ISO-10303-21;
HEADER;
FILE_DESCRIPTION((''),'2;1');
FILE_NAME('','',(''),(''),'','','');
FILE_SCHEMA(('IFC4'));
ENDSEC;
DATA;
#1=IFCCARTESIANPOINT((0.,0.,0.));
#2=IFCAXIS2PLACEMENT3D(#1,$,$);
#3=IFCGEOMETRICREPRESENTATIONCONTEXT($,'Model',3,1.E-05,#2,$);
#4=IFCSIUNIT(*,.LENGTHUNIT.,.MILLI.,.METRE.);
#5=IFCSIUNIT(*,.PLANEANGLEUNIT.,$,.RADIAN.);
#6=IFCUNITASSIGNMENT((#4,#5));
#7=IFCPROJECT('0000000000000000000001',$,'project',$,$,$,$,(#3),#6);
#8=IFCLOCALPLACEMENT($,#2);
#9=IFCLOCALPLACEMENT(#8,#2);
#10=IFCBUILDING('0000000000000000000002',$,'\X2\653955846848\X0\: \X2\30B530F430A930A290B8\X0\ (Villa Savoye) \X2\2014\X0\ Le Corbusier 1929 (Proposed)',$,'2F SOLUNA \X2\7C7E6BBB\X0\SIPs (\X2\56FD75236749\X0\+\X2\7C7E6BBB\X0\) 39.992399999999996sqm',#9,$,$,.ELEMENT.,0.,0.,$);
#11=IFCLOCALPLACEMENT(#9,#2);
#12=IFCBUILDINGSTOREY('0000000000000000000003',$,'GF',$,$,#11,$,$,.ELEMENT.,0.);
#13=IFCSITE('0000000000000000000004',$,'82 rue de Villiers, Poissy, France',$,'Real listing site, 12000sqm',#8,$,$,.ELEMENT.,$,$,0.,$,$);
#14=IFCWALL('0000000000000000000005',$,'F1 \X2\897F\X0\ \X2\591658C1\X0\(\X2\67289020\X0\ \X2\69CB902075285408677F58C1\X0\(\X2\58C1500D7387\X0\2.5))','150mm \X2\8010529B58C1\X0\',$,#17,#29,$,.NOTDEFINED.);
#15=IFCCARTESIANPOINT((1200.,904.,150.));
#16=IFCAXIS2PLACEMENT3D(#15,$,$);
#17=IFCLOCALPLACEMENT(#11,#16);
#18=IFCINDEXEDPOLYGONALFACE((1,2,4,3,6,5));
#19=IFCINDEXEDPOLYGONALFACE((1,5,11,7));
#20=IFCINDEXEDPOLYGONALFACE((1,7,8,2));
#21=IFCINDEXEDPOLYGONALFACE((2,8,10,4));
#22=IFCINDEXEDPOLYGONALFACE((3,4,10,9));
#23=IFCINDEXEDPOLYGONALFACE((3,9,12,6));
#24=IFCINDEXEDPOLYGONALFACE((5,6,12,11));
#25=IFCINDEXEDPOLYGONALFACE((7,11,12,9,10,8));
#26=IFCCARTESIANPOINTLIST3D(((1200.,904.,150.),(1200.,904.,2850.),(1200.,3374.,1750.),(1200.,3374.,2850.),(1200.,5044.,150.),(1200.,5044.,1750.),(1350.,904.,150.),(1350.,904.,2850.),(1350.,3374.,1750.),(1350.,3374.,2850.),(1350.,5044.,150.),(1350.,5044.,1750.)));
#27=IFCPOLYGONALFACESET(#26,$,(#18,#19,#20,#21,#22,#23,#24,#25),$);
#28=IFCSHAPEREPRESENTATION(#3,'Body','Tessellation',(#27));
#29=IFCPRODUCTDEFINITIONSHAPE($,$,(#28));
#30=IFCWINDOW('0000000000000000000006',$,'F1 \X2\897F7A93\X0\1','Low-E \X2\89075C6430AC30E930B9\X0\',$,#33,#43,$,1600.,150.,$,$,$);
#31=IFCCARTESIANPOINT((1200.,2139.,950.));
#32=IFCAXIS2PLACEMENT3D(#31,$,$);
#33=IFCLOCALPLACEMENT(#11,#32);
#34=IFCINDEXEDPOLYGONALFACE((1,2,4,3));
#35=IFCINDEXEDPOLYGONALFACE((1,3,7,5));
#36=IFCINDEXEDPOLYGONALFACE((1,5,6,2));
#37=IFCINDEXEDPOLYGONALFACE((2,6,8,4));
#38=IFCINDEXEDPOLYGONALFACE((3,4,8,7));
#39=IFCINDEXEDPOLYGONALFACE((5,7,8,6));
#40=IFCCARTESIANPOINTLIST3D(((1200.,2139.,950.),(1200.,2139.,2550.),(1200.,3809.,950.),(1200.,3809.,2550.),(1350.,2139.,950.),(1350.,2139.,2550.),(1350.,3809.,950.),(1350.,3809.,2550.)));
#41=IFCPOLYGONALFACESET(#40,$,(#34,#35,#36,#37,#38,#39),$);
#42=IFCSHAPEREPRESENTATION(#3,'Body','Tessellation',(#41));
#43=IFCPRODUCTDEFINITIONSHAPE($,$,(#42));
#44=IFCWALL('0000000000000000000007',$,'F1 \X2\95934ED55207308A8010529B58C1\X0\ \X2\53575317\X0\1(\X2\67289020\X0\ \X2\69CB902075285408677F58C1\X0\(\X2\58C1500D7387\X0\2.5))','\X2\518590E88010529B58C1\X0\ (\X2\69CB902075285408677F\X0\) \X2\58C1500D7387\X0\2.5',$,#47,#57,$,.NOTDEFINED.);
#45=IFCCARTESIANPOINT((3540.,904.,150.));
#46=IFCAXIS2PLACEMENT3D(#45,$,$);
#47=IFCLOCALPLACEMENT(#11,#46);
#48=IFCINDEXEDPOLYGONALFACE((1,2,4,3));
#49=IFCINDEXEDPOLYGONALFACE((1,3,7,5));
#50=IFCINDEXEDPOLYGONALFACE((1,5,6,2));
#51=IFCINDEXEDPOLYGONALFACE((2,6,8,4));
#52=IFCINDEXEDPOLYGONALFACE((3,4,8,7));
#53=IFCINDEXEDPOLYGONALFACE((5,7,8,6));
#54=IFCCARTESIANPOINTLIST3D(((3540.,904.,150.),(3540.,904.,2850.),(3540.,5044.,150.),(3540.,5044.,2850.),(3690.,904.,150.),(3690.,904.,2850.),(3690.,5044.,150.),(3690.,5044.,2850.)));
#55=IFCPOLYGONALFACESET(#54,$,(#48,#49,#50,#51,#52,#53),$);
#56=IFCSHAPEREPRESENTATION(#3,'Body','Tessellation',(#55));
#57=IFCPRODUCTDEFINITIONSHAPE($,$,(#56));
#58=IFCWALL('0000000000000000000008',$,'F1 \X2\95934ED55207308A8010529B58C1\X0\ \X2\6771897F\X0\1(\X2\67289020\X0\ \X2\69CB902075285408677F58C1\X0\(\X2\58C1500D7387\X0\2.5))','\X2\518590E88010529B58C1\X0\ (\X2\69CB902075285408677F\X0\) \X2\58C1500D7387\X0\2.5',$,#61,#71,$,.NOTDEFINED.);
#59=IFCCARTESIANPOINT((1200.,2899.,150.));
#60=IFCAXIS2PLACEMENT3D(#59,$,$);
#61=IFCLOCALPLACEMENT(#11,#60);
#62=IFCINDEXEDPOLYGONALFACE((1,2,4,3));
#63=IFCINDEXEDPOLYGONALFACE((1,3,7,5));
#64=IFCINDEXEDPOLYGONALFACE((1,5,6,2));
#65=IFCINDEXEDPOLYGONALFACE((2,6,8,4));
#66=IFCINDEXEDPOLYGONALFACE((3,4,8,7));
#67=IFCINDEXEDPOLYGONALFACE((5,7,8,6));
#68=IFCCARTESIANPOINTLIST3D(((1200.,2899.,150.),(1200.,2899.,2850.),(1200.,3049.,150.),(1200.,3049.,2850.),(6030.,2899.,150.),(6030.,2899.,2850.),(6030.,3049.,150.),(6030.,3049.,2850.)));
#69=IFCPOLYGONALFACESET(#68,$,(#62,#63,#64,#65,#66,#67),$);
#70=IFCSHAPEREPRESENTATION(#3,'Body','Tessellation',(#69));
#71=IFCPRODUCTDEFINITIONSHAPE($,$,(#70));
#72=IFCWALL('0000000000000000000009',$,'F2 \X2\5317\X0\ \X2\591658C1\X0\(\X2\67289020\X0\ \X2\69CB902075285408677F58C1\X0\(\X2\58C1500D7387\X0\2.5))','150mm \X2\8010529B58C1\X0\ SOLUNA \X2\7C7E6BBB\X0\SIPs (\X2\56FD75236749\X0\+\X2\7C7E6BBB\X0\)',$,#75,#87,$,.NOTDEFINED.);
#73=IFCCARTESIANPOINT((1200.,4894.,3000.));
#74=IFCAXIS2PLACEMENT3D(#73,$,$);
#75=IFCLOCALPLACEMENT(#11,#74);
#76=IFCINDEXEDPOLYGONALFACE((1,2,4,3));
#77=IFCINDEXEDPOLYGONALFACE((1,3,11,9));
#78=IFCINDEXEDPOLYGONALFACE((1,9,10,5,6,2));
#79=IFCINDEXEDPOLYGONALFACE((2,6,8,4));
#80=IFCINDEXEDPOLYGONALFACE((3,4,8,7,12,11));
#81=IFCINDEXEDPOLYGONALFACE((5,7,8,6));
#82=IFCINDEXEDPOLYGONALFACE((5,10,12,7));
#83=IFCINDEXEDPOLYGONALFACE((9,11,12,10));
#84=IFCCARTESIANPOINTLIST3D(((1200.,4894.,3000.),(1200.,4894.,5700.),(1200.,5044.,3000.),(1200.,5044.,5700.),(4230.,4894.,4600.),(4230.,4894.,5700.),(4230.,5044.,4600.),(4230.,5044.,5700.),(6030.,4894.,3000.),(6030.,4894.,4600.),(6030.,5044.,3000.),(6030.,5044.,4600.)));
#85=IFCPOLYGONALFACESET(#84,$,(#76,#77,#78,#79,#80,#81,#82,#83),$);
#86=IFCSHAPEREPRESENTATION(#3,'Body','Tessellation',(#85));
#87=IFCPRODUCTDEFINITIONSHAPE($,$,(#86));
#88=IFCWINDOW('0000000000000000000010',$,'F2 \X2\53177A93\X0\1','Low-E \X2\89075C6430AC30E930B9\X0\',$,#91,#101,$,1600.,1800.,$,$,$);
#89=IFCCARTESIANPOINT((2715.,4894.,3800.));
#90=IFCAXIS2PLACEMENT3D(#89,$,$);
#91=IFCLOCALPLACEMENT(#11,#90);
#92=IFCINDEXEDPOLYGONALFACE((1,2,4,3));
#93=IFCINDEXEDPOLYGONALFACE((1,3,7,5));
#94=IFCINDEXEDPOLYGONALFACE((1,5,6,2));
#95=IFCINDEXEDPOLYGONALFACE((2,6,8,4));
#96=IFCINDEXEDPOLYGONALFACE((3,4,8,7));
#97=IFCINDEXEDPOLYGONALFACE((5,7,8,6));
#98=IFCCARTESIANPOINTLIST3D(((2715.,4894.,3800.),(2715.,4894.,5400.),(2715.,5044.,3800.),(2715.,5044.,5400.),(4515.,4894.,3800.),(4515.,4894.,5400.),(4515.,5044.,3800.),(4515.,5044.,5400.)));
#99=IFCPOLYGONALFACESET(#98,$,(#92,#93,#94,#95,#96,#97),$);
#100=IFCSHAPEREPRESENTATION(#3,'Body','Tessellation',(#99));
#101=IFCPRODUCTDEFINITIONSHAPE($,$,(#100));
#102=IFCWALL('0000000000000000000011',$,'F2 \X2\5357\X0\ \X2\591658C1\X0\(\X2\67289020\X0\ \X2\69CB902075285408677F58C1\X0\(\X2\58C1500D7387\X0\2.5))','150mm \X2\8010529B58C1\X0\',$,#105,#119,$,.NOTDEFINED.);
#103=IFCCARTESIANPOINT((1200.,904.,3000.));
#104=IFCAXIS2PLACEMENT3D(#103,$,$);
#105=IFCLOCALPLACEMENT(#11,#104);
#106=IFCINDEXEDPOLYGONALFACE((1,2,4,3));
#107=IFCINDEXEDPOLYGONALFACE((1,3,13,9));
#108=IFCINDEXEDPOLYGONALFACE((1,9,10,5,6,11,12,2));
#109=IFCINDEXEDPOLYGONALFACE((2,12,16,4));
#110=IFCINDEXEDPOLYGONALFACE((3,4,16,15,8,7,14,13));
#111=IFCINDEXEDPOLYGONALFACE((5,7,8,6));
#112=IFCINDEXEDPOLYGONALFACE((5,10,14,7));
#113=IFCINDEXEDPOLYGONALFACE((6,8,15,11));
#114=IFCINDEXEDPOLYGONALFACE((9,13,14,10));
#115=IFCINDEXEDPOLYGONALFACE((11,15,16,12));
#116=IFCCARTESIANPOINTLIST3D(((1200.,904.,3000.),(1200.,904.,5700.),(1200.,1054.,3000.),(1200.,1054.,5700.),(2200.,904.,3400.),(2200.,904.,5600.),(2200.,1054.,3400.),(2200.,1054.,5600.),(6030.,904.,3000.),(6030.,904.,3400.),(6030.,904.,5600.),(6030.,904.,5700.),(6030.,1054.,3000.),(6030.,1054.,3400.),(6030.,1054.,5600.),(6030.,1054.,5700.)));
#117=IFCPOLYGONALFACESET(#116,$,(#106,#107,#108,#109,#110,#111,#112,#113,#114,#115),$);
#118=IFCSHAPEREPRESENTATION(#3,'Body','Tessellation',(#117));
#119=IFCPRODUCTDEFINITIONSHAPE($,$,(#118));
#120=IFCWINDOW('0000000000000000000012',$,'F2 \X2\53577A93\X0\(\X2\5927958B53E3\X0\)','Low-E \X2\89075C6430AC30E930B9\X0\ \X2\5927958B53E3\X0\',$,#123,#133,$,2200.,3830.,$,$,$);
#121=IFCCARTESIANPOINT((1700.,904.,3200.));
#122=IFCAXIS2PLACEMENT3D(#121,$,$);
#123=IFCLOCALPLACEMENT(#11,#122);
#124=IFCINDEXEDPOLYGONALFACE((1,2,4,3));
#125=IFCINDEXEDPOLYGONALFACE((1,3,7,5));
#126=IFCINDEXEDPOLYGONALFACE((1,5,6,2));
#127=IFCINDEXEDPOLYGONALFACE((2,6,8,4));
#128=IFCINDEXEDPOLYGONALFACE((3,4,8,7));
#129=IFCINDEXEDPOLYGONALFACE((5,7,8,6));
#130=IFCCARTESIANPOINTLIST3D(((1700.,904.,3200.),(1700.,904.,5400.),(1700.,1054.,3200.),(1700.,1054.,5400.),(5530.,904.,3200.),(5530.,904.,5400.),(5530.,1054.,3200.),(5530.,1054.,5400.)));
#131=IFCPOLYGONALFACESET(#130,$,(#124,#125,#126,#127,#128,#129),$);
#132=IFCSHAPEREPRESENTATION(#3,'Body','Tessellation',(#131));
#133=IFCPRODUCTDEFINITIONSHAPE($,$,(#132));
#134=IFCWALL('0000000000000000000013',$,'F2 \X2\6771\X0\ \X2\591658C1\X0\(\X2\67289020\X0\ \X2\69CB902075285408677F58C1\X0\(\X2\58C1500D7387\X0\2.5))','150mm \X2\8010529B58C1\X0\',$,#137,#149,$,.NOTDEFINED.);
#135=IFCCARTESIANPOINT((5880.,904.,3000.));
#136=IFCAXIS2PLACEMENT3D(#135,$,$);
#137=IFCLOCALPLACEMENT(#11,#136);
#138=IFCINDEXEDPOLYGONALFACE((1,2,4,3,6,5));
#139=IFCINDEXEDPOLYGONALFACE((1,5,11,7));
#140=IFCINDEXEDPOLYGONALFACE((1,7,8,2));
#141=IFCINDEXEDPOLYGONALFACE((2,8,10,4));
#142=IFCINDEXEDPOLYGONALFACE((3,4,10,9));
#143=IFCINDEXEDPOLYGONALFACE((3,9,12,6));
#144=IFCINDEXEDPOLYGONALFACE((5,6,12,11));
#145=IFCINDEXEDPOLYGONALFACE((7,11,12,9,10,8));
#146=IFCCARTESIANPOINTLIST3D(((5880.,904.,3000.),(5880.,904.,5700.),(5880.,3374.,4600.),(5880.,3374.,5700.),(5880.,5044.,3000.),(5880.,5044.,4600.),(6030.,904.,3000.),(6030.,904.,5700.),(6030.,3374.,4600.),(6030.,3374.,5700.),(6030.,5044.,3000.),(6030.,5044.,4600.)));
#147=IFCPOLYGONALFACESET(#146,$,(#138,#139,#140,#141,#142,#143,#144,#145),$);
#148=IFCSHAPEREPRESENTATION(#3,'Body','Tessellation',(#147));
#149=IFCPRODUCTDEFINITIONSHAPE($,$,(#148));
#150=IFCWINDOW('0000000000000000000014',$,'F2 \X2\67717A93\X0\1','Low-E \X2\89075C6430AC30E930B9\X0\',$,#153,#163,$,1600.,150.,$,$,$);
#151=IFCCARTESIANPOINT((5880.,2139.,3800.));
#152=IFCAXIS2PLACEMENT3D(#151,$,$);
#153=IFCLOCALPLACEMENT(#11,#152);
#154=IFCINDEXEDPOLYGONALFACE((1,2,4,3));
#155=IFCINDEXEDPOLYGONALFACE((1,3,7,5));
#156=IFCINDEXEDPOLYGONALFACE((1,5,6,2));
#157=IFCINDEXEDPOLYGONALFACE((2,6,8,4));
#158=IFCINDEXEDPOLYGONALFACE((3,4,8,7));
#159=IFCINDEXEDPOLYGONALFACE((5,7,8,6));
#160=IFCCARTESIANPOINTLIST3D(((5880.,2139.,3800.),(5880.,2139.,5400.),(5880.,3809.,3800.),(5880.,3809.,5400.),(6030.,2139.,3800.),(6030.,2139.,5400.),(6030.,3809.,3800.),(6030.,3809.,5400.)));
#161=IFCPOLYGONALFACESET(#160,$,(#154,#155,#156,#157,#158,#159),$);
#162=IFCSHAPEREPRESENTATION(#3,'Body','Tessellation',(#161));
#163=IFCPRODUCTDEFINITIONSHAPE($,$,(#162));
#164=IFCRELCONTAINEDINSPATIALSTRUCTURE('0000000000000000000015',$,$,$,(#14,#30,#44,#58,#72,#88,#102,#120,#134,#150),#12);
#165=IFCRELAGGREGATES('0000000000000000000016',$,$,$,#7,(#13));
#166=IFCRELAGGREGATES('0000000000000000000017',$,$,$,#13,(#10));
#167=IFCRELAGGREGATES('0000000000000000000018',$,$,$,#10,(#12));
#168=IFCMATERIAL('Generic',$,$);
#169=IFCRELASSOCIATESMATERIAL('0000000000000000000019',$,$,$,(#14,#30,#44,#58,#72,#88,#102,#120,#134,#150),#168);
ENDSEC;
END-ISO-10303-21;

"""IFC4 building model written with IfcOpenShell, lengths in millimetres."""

from ifc_helpers import new_model, si_unit, frame, frame_2d, origin, place, context, project, spatial, rectangle, extrude, material, element, fill, save


model = new_model("IFC4")

# Units and contexts
model_context = context("Model", 3, precision=1e-05, world=origin())
ifc_project = project(units=[si_unit("LENGTHUNIT", "METRE", prefix="MILLI"), si_unit("PLANEANGLEUNIT", "RADIAN")], contexts=[model_context])

# Site, building, storey
site_placement = place(None, origin())
site = spatial("IfcSite", under=ifc_project, at=site_placement, Name="82 rue de Villiers, Poissy, France", ObjectType="Real listing site, 12000sqm", CompositionType="ELEMENT", RefElevation=0.0)
building_placement = place(site_placement, origin())
building = spatial("IfcBuilding", under=site, at=building_placement, Name="改善案: サヴォア邸 (Villa Savoye) — Le Corbusier 1929 (Proposed)", ObjectType="2F SOLUNA 籾殻SIPs (国産杉+籾殻) 39.992399999999996sqm", CompositionType="ELEMENT", ElevationOfRefHeight=0.0, ElevationOfTerrain=0.0)
storey_placement = place(building_placement, origin())
storey = spatial("IfcBuildingStorey", under=building, at=storey_placement, Name="GF", CompositionType="ELEMENT", Elevation=0.0)

# Shared definitions
ifc_material_1 = material(Name="Generic")

# Wall, opening, window
wall_1_placement = place(storey_placement, frame((1200.0, 904.0, 150.0)))
wall_1 = element("IfcWall", 1, at=wall_1_placement, inside=storey, material=ifc_material_1, Name="F1 西 外壁(木造 構造用合板壁(壁倍率2.5))", Description="150mm 耐力壁", PredefinedType="NOTDEFINED", context=model_context, shape_type="SweptSolid", body=[
    extrude(rectangle(XDim=150.0, YDim=4140.0, at=frame_2d((75.0, 2070.0))), frame((1200.0, 904.0, 150.0)), (0.0, 0.0, 1.0), 2700.0),
])
opening_1_placement = place(storey_placement, frame((1200.0, 2139.0, 950.0)))
opening_1 = element("IfcOpeningElement", 2, at=opening_1_placement, cuts=wall_1, PredefinedType="NOTDEFINED", context=model_context, shape_type="SweptSolid", body=[
    extrude(rectangle(XDim=150.0, YDim=1670.0, at=frame_2d((75.0, 835.0))), frame((1200.0, 2139.0, 950.0)), (0.0, 0.0, 1.0), 1600.0),
])
window_1_placement = place(storey_placement, frame((1200.0, 2139.0, 950.0)))
window_1 = element("IfcWindow", 3, at=window_1_placement, inside=storey, material=ifc_material_1, Name="F1 西窓1", Description="Low-E 複層ガラス", OverallHeight=1600.0, OverallWidth=150.0, context=model_context, shape_type="SweptSolid", body=[
    extrude(rectangle(XDim=150.0, YDim=1670.0, at=frame_2d((75.0, 835.0))), frame((1200.0, 2139.0, 950.0)), (0.0, 0.0, 1.0), 1600.0),
])
fill(opening_1, window_1)

# Walls
wall_2_placement = place(storey_placement, frame((3540.0, 904.0, 150.0)))
element("IfcWall", 4, at=wall_2_placement, inside=storey, material=ifc_material_1, Name="F1 間仕切り耐力壁 南北1(木造 構造用合板壁(壁倍率2.5))", Description="内部耐力壁 (構造用合板) 壁倍率2.5", PredefinedType="NOTDEFINED", context=model_context, shape_type="SweptSolid", body=[
    extrude(rectangle(XDim=150.0, YDim=4140.0, at=frame_2d((75.0, 2070.0))), frame((3540.0, 904.0, 150.0)), (0.0, 0.0, 1.0), 2700.0),
])
wall_3_placement = place(storey_placement, frame((1200.0, 2899.0, 150.0)))
element("IfcWall", 5, at=wall_3_placement, inside=storey, material=ifc_material_1, Name="F1 間仕切り耐力壁 東西1(木造 構造用合板壁(壁倍率2.5))", Description="内部耐力壁 (構造用合板) 壁倍率2.5", PredefinedType="NOTDEFINED", context=model_context, shape_type="SweptSolid", body=[
    extrude(rectangle(XDim=4830.0, YDim=150.0, at=frame_2d((2415.0, 75.0))), frame((1200.0, 2899.0, 150.0)), (0.0, 0.0, 1.0), 2700.0),
])

# Walls, openings, windows
wall_4_placement = place(storey_placement, frame((1200.0, 4894.0, 3000.0)))
wall_4 = element("IfcWall", 6, at=wall_4_placement, inside=storey, material=ifc_material_1, Name="F2 北 外壁(木造 構造用合板壁(壁倍率2.5))", Description="150mm 耐力壁 SOLUNA 籾殻SIPs (国産杉+籾殻)", PredefinedType="NOTDEFINED", context=model_context, shape_type="SweptSolid", body=[
    extrude(rectangle(XDim=4830.0, YDim=150.0, at=frame_2d((2415.0, 75.0))), frame((1200.0, 4894.0, 3000.0)), (0.0, 0.0, 1.0), 2700.0),
])
opening_2_placement = place(storey_placement, frame((2715.0, 4894.0, 3800.0)))
opening_2 = element("IfcOpeningElement", 7, at=opening_2_placement, cuts=wall_4, PredefinedType="NOTDEFINED", context=model_context, shape_type="SweptSolid", body=[
    extrude(rectangle(XDim=1800.0, YDim=150.0, at=frame_2d((900.0, 75.0))), frame((2715.0, 4894.0, 3800.0)), (0.0, 0.0, 1.0), 1600.0),
])
window_2_placement = place(storey_placement, frame((2715.0, 4894.0, 3800.0)))
window_2 = element("IfcWindow", 8, at=window_2_placement, inside=storey, material=ifc_material_1, Name="F2 北窓1", Description="Low-E 複層ガラス", OverallHeight=1600.0, OverallWidth=1800.0, context=model_context, shape_type="SweptSolid", body=[
    extrude(rectangle(XDim=1800.0, YDim=150.0, at=frame_2d((900.0, 75.0))), frame((2715.0, 4894.0, 3800.0)), (0.0, 0.0, 1.0), 1600.0),
])
fill(opening_2, window_2)
wall_5_placement = place(storey_placement, frame((1200.0, 904.0, 3000.0)))
wall_5 = element("IfcWall", 9, at=wall_5_placement, inside=storey, material=ifc_material_1, Name="F2 南 外壁(木造 構造用合板壁(壁倍率2.5))", Description="150mm 耐力壁", PredefinedType="NOTDEFINED", context=model_context, shape_type="SweptSolid", body=[
    extrude(rectangle(XDim=4830.0, YDim=150.0, at=frame_2d((2415.0, 75.0))), frame((1200.0, 904.0, 3000.0)), (0.0, 0.0, 1.0), 2700.0),
])
opening_3_placement = place(storey_placement, frame((1700.0, 904.0, 3200.0)))
opening_3 = element("IfcOpeningElement", 10, at=opening_3_placement, cuts=wall_5, PredefinedType="NOTDEFINED", context=model_context, shape_type="SweptSolid", body=[
    extrude(rectangle(XDim=3830.0, YDim=150.0, at=frame_2d((1915.0, 75.0))), frame((1700.0, 904.0, 3200.0)), (0.0, 0.0, 1.0), 2200.0),
])
window_3_placement = place(storey_placement, frame((1700.0, 904.0, 3200.0)))
window_3 = element("IfcWindow", 11, at=window_3_placement, inside=storey, material=ifc_material_1, Name="F2 南窓(大開口)", Description="Low-E 複層ガラス 大開口", OverallHeight=2200.0, OverallWidth=3830.0, context=model_context, shape_type="SweptSolid", body=[
    extrude(rectangle(XDim=3830.0, YDim=150.0, at=frame_2d((1915.0, 75.0))), frame((1700.0, 904.0, 3200.0)), (0.0, 0.0, 1.0), 2200.0),
])
fill(opening_3, window_3)
wall_6_placement = place(storey_placement, frame((5880.0, 904.0, 3000.0)))
wall_6 = element("IfcWall", 12, at=wall_6_placement, inside=storey, material=ifc_material_1, Name="F2 東 外壁(木造 構造用合板壁(壁倍率2.5))", Description="150mm 耐力壁", PredefinedType="NOTDEFINED", context=model_context, shape_type="SweptSolid", body=[
    extrude(rectangle(XDim=150.0, YDim=4140.0, at=frame_2d((75.0, 2070.0))), frame((5880.0, 904.0, 3000.0)), (0.0, 0.0, 1.0), 2700.0),
])
opening_4_placement = place(storey_placement, frame((5880.0, 2139.0, 3800.0)))
opening_4 = element("IfcOpeningElement", 13, at=opening_4_placement, cuts=wall_6, PredefinedType="NOTDEFINED", context=model_context, shape_type="SweptSolid", body=[
    extrude(rectangle(XDim=150.0, YDim=1670.0, at=frame_2d((75.0, 835.0))), frame((5880.0, 2139.0, 3800.0)), (0.0, 0.0, 1.0), 1600.0),
])
window_4_placement = place(storey_placement, frame((5880.0, 2139.0, 3800.0)))
window_4 = element("IfcWindow", 14, at=window_4_placement, inside=storey, material=ifc_material_1, Name="F2 東窓1", Description="Low-E 複層ガラス", OverallHeight=1600.0, OverallWidth=150.0, context=model_context, shape_type="SweptSolid", body=[
    extrude(rectangle(XDim=150.0, YDim=1670.0, at=frame_2d((75.0, 835.0))), frame((5880.0, 2139.0, 3800.0)), (0.0, 0.0, 1.0), 1600.0),
])
fill(opening_4, window_4)

save(model, "model.ifc")
